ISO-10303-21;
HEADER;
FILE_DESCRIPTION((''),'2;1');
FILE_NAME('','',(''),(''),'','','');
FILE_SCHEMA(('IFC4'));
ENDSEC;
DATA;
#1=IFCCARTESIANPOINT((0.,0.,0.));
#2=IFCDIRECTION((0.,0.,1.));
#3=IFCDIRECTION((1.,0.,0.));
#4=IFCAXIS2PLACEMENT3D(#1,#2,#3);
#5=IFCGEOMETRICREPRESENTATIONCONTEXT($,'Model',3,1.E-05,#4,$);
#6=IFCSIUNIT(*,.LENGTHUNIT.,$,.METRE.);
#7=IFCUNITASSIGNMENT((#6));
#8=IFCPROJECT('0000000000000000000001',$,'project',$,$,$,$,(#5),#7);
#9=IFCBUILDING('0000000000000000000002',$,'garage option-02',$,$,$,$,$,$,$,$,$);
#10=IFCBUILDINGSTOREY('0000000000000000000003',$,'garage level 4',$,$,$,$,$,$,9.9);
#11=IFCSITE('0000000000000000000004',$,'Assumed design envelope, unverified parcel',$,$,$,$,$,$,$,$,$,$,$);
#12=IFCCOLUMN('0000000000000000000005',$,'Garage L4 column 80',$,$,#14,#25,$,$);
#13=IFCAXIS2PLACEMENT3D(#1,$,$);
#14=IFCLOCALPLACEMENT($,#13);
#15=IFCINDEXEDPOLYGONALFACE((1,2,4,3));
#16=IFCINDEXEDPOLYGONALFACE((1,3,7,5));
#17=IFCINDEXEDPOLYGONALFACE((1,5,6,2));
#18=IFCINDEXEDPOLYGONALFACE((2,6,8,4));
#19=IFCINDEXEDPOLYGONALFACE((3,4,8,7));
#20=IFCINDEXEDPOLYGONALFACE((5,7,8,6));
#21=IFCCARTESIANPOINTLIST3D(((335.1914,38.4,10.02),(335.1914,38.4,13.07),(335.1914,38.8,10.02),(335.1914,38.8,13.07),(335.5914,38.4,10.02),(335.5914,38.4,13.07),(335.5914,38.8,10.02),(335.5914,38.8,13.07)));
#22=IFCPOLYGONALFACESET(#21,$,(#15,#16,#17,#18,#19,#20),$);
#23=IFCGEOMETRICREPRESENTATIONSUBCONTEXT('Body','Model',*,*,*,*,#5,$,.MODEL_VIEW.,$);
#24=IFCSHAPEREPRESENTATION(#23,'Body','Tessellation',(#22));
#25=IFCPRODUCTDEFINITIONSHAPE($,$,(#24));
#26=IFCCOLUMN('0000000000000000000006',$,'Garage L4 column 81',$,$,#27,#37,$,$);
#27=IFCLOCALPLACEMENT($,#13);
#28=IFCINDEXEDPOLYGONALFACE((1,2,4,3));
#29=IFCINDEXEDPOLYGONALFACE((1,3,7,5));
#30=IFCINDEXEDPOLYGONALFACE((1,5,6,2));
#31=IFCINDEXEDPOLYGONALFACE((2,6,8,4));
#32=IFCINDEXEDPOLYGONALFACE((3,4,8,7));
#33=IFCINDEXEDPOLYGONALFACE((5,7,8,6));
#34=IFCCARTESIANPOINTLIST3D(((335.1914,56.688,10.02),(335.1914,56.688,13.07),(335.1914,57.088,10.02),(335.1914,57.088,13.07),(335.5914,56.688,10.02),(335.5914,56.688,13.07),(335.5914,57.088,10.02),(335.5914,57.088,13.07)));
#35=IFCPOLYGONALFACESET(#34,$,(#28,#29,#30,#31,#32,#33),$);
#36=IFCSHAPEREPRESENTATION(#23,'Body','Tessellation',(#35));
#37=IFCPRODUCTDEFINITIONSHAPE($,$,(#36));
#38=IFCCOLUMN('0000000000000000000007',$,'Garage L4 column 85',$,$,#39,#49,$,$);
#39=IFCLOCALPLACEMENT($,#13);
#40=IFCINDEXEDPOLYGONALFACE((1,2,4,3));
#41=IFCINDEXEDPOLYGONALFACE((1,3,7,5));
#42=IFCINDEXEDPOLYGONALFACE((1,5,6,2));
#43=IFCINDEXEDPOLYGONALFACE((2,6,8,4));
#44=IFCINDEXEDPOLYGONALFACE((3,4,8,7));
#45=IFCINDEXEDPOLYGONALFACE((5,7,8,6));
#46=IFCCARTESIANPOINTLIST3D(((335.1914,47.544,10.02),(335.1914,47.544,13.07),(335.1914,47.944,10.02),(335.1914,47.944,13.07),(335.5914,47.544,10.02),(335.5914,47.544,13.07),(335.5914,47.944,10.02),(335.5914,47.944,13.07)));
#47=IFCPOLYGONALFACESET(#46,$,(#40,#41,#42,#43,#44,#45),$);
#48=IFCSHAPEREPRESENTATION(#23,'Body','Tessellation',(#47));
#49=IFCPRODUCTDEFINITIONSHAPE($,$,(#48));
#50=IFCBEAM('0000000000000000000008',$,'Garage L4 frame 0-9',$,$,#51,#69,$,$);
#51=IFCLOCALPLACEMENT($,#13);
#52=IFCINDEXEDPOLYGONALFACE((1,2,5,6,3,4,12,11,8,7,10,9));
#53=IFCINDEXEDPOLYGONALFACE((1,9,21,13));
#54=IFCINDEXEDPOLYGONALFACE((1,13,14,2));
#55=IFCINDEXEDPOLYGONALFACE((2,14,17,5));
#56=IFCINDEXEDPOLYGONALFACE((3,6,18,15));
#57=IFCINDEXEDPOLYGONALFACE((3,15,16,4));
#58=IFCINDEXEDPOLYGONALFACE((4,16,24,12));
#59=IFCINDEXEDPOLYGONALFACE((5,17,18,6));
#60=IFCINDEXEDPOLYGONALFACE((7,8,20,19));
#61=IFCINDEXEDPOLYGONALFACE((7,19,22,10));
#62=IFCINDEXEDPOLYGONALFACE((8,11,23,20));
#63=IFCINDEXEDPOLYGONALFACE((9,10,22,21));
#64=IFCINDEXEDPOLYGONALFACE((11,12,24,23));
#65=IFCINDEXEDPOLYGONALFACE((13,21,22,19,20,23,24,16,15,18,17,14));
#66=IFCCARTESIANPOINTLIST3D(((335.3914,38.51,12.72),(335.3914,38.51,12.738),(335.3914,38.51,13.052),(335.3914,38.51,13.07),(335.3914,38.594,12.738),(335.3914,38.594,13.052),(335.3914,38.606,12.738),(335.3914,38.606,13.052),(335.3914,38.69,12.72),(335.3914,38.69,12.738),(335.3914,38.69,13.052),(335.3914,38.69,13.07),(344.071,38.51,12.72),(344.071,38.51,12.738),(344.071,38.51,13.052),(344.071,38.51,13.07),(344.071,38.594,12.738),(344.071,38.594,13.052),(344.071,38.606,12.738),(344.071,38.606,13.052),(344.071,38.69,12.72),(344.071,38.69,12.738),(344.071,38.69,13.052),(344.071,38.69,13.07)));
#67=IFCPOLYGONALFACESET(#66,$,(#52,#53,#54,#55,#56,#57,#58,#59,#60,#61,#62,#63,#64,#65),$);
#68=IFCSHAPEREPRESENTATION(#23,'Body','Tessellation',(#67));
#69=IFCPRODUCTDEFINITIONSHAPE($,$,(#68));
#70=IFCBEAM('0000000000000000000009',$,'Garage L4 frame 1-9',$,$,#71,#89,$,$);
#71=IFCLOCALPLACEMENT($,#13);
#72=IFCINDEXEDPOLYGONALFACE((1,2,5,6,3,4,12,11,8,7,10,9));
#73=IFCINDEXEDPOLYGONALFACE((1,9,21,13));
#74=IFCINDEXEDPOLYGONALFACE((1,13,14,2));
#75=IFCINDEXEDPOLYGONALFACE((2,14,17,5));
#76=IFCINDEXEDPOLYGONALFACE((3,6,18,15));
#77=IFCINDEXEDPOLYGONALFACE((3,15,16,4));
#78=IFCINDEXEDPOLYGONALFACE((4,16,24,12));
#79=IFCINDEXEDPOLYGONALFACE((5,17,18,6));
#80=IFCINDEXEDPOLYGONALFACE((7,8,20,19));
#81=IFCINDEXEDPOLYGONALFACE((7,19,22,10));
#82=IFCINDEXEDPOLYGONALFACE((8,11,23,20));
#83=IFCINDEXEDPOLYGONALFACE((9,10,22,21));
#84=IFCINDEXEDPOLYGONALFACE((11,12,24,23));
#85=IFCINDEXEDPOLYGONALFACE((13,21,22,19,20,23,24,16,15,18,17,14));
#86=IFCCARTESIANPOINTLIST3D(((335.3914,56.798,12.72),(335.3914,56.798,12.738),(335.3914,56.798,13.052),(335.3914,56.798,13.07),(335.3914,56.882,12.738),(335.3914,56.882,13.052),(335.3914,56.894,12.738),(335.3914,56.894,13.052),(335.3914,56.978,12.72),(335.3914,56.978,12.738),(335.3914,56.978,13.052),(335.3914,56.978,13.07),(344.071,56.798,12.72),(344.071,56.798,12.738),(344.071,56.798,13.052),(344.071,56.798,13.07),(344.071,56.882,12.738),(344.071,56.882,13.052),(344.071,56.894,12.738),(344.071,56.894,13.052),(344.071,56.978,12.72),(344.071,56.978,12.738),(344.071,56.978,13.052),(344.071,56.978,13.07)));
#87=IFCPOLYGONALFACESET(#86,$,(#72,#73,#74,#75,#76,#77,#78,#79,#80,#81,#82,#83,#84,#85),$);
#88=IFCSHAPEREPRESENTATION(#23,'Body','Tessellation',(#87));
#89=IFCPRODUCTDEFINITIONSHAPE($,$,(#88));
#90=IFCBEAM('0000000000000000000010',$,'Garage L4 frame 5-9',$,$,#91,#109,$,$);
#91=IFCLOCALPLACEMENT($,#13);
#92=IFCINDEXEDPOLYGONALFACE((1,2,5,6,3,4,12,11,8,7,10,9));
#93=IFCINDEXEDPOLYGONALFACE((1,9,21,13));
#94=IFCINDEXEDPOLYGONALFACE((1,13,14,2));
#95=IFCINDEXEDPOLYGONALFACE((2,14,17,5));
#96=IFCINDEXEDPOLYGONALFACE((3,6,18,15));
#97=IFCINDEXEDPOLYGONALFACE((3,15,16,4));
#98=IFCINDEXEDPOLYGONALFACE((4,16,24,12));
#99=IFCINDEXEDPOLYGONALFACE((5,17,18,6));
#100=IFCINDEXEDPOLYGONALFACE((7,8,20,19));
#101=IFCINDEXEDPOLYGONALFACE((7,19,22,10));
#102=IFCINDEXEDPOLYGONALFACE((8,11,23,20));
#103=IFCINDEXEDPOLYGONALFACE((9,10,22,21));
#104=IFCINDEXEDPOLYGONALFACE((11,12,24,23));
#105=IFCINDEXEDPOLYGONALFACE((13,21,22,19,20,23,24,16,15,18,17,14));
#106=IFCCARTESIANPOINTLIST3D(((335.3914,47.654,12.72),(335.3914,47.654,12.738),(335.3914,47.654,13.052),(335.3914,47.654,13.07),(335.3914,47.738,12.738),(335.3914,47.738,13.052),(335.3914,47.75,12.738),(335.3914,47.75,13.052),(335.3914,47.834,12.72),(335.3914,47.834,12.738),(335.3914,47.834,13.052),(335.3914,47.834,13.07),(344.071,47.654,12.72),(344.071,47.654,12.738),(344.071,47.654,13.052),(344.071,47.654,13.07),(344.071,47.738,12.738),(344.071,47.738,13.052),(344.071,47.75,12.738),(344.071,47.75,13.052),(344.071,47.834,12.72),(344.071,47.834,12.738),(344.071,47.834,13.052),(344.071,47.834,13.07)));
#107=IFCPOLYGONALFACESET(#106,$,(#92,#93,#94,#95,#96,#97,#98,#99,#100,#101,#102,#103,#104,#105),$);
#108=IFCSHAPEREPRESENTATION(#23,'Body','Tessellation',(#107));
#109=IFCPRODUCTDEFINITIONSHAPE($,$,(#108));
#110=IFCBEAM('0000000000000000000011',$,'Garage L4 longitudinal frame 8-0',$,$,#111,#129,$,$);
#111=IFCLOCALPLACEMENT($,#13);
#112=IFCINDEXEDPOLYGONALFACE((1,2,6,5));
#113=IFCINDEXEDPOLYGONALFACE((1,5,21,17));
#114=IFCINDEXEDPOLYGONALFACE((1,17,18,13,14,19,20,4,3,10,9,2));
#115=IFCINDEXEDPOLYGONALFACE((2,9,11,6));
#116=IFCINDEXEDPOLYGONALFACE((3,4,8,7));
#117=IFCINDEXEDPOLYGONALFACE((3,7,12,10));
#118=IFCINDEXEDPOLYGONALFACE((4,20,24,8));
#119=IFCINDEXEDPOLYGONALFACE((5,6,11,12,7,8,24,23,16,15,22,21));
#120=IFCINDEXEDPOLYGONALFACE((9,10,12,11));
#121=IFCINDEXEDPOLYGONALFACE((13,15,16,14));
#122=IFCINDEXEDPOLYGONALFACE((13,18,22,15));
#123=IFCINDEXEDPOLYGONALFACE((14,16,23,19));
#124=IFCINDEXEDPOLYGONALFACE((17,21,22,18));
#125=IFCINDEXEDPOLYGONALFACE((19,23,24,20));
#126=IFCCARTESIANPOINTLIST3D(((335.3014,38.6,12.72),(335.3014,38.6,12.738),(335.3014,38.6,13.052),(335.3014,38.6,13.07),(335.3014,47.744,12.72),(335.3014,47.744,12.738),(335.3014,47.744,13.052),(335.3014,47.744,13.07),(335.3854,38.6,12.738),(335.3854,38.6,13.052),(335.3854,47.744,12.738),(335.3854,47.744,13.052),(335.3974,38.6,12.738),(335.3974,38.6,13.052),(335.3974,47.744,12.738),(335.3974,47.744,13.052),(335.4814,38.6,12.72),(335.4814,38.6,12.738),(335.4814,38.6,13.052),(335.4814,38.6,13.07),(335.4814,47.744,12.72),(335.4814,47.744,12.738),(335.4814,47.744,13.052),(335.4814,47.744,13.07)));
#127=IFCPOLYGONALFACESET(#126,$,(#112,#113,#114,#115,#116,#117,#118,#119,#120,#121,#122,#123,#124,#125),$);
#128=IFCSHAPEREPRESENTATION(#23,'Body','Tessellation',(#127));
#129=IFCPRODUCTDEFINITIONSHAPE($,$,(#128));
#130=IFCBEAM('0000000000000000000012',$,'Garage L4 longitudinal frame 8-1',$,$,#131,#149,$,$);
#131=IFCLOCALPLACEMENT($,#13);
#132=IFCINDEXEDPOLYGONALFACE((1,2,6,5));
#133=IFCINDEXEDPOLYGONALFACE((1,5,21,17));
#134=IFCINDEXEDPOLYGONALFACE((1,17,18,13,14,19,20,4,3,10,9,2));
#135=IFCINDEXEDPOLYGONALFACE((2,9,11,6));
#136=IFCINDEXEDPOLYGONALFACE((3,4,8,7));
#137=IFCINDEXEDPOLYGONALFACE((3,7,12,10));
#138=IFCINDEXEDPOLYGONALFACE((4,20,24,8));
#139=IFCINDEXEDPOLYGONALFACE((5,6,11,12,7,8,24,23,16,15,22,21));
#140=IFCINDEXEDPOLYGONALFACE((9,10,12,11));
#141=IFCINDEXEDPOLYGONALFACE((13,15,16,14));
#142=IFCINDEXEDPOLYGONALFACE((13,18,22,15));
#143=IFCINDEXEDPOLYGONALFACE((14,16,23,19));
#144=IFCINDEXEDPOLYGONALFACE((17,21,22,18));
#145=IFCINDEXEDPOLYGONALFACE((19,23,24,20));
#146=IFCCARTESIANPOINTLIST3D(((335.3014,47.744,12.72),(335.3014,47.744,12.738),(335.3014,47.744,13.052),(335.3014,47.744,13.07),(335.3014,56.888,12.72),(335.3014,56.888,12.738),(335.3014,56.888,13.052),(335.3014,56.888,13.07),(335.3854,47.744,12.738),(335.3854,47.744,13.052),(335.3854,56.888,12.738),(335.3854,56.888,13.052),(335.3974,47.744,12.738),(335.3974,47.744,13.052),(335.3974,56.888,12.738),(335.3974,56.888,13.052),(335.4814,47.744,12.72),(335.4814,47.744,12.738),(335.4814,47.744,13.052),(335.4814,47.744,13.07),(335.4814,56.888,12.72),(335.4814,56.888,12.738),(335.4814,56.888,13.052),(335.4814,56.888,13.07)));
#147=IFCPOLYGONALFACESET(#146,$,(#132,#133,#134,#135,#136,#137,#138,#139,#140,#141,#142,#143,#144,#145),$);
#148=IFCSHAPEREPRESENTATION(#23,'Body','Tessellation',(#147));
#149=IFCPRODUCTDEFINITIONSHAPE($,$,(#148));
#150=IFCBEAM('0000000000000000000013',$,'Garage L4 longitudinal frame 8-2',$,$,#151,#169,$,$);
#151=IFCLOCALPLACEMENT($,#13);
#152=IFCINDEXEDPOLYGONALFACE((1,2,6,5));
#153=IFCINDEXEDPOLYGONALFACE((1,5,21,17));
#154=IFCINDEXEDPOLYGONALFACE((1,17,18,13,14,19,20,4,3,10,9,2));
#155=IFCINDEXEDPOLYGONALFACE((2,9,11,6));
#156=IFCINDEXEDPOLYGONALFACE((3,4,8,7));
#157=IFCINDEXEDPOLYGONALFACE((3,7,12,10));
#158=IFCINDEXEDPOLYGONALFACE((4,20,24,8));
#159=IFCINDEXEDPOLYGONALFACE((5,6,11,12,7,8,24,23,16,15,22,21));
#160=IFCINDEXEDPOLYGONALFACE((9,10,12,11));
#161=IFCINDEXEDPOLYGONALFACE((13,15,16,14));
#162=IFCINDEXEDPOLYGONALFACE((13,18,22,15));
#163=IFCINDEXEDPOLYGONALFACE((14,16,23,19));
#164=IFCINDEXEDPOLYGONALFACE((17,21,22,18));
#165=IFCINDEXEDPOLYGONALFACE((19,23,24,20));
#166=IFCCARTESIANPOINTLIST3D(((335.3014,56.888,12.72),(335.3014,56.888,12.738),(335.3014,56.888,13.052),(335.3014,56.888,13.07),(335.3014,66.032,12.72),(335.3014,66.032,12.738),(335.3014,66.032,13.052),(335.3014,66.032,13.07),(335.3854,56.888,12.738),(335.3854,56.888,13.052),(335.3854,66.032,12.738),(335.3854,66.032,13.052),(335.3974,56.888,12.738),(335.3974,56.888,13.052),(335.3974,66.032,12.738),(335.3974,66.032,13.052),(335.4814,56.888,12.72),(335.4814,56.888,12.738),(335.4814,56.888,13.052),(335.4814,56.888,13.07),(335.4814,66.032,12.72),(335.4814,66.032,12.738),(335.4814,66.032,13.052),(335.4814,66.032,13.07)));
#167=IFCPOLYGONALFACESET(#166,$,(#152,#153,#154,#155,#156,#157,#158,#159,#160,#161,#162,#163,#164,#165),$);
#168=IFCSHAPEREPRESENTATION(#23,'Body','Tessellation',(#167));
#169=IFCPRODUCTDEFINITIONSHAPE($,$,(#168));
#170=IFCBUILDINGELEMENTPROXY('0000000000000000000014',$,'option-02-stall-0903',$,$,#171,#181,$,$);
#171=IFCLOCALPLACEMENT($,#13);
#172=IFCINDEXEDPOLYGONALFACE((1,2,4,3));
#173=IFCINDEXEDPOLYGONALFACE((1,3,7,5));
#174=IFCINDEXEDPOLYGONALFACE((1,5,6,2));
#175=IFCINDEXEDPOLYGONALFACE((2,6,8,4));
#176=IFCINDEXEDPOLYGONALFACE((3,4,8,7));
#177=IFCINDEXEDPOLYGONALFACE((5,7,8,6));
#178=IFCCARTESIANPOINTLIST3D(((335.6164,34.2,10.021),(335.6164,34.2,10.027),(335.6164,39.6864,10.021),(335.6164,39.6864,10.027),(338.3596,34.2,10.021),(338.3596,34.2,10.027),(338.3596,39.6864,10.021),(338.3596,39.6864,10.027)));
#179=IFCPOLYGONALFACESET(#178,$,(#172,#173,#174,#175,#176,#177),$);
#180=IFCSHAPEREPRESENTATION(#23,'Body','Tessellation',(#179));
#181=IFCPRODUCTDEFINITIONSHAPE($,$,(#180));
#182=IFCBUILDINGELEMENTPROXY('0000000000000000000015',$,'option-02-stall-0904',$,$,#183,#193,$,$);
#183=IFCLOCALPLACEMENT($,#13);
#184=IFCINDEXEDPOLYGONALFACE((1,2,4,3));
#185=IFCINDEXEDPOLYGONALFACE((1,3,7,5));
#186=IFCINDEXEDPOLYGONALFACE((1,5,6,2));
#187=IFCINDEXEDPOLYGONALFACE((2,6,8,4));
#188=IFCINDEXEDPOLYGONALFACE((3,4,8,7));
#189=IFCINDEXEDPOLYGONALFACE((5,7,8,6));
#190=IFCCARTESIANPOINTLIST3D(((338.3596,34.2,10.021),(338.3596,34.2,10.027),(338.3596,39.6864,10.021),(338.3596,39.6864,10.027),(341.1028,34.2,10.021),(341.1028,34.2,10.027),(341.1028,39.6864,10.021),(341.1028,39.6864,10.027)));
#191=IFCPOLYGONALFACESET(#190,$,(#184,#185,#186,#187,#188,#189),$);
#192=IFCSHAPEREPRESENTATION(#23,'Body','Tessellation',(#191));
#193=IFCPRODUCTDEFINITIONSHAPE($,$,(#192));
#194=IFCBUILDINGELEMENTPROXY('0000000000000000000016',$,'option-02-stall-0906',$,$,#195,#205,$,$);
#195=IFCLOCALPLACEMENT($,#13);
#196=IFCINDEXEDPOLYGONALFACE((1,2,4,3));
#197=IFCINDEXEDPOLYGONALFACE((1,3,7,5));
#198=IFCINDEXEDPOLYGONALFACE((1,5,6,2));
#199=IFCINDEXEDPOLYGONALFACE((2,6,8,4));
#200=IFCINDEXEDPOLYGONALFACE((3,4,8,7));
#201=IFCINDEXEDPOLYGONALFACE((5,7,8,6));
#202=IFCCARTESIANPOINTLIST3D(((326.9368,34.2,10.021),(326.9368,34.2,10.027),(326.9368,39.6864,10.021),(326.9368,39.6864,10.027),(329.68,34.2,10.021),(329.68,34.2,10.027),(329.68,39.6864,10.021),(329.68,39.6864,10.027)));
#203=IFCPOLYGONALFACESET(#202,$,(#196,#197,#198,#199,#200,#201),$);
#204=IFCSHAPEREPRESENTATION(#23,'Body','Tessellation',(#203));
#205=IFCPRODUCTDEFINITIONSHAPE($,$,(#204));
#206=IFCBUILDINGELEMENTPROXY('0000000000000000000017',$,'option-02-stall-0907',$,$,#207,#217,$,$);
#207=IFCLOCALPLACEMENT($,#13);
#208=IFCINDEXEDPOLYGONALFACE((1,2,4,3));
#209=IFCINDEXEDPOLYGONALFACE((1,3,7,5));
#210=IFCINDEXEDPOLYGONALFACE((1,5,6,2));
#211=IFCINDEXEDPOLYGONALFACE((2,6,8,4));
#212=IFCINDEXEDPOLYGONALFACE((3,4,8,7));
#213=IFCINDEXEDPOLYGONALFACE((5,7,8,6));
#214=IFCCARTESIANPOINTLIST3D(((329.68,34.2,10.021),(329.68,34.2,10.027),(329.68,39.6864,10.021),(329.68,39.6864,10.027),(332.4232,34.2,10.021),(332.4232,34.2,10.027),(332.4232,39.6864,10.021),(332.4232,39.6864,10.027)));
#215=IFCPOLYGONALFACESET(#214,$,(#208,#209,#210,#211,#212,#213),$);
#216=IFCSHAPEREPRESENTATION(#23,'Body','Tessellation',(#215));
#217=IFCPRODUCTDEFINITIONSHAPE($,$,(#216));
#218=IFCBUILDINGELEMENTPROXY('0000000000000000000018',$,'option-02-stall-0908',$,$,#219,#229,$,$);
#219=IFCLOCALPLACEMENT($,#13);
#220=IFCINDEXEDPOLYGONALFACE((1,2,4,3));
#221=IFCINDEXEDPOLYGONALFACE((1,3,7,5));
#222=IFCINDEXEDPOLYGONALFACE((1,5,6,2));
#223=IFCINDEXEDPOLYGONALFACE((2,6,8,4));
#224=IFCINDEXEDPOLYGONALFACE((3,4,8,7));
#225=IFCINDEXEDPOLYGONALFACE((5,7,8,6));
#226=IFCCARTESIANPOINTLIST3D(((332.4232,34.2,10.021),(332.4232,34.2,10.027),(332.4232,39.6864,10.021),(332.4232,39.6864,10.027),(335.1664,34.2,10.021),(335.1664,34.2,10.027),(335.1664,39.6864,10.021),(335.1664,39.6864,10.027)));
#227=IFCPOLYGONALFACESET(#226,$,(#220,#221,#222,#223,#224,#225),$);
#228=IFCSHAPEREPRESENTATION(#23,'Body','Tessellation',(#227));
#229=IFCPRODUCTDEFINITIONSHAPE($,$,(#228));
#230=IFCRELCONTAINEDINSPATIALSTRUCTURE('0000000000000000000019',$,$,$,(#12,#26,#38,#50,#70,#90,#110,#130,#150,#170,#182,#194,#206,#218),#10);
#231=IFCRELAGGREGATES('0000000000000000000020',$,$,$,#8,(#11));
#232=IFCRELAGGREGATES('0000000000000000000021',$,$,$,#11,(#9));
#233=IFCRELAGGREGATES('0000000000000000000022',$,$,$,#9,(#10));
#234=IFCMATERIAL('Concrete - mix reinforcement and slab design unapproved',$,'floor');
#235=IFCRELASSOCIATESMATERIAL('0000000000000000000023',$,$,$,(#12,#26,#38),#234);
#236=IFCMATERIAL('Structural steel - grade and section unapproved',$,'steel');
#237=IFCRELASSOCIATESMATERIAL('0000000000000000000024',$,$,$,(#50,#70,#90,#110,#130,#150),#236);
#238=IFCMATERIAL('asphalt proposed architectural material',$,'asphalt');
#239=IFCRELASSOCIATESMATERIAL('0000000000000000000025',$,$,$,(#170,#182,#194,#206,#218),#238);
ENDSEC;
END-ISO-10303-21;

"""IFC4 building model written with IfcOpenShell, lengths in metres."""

from ifc_helpers import new_model, si_unit, frame, origin_with_axes, place, context, subcontext, project, spatial, rectangle, i_section, extrude, material, element, save


model = new_model("IFC4")

# Units and contexts
model_context = context("Model", 3, precision=1e-05, world=origin_with_axes())
body_context = subcontext(model_context, "Body", "Model", "MODEL_VIEW")
ifc_project = project(units=[si_unit("LENGTHUNIT", "METRE")], contexts=[model_context])

# Site, building, storey
site = spatial("IfcSite", under=ifc_project, Name="Assumed design envelope, unverified parcel")
building = spatial("IfcBuilding", under=site, Name="garage option-02")
storey = spatial("IfcBuildingStorey", under=building, Name="garage level 4", Elevation=9.9)

# Columns
ifc_material_1 = material(Name="Concrete - mix reinforcement and slab design unapproved", Category="floor")
for number, where, z_axis, x_axis, name in (
    (1, (335.3914, 38.6, 10.02), (0.0, 0.0, 1.0), (1.0, 0.0, 0.0), "Garage L4 column 80"),
    (2, (335.3914, 56.888, 10.02), (0.0, 0.0, 1.0), (1.0, 0.0, 0.0), "Garage L4 column 81"),
    (3, (335.3914, 47.744, 10.02), (0.0, 0.0, 1.0), (1.0, 0.0, 0.0), "Garage L4 column 85"),
):
    element("IfcColumn", number, at=place(None, frame(where, z_axis=z_axis, x_axis=x_axis)), inside=storey, material=ifc_material_1, Name=name, context=body_context, shape_type="SweptSolid", body=[
        extrude(rectangle(XDim=0.4, YDim=0.4), origin_with_axes(), (0.0, 0.0, 1.0), 3.05),
    ])

# Beams
ifc_material_2 = material(Name="Structural steel - grade and section unapproved", Category="steel")
for number, where, z_axis, x_axis, name in (
    (4, (335.3914, 38.6, 12.895), (1.0, 0.0, 0.0), (0.0, 1.0, 0.0), "Garage L4 frame 0-9"),
    (5, (335.3914, 56.888, 12.895), (1.0, 0.0, 0.0), (0.0, 1.0, 0.0), "Garage L4 frame 1-9"),
    (6, (335.3914, 47.744, 12.895), (1.0, 0.0, 0.0), (0.0, 1.0, 0.0), "Garage L4 frame 5-9"),
):
    element("IfcBeam", number, at=place(None, frame(where, z_axis=z_axis, x_axis=x_axis)), inside=storey, material=ifc_material_2, Name=name, context=body_context, shape_type="SweptSolid", body=[
        extrude(i_section(OverallWidth=0.18, OverallDepth=0.35, WebThickness=0.012, FlangeThickness=0.018, FilletRadius=0.0), origin_with_axes(), (0.0, 0.0, 1.0), 8.6796),
    ])
for number, where, z_axis, x_axis, name in (
    (7, (335.3914, 38.6, 12.895), (0.0, 1.0, 0.0), (-1.0, 0.0, 0.0), "Garage L4 longitudinal frame 8-0"),
    (8, (335.3914, 47.744, 12.895), (0.0, 1.0, 0.0), (-1.0, 0.0, 0.0), "Garage L4 longitudinal frame 8-1"),
):
    element("IfcBeam", number, at=place(None, frame(where, z_axis=z_axis, x_axis=x_axis)), inside=storey, material=ifc_material_2, Name=name, context=body_context, shape_type="SweptSolid", body=[
        extrude(i_section(OverallWidth=0.18, OverallDepth=0.35, WebThickness=0.012, FlangeThickness=0.018, FilletRadius=0.0), origin_with_axes(), (0.0, 0.0, 1.0), 9.144),
    ])
beam_placement = place(None, frame((335.3914, 56.888, 12.895), z_axis=(0.0, 1.0, 0.0), x_axis=(-1.0, 0.0, 0.0)))
element("IfcBeam", 9, at=beam_placement, inside=storey, material=ifc_material_2, Name="Garage L4 longitudinal frame 8-2", context=body_context, shape_type="SweptSolid", body=[
    extrude(i_section(OverallWidth=0.18, OverallDepth=0.35, WebThickness=0.012, FlangeThickness=0.018, FilletRadius=0.0), origin_with_axes(), (0.0, 0.0, 1.0), 9.144),
])

# Building element proxies
ifc_material_3 = material(Name="asphalt proposed architectural material", Category="asphalt")
for number, where, z_axis, x_axis, name in (
    (10, (336.988, 36.9432, 10.021), (0.0, 0.0, 1.0), (1.0, 0.0, 0.0), "option-02-stall-0903"),
    (11, (339.7312, 36.9432, 10.021), (0.0, 0.0, 1.0), (1.0, 0.0, 0.0), "option-02-stall-0904"),
    (12, (328.3084, 36.9432, 10.021), (0.0, 0.0, 1.0), (1.0, 0.0, 0.0), "option-02-stall-0906"),
    (13, (331.0516, 36.9432, 10.021), (0.0, 0.0, 1.0), (1.0, 0.0, 0.0), "option-02-stall-0907"),
    (14, (333.7948, 36.9432, 10.021), (0.0, 0.0, 1.0), (1.0, 0.0, 0.0), "option-02-stall-0908"),
):
    element("IfcBuildingElementProxy", number, at=place(None, frame(where, z_axis=z_axis, x_axis=x_axis)), inside=storey, material=ifc_material_3, Name=name, context=body_context, shape_type="SweptSolid", body=[
        extrude(rectangle(XDim=2.7432, YDim=5.4864), origin_with_axes(), (0.0, 0.0, 1.0), 0.006),
    ])

save(model, "model.ifc")
